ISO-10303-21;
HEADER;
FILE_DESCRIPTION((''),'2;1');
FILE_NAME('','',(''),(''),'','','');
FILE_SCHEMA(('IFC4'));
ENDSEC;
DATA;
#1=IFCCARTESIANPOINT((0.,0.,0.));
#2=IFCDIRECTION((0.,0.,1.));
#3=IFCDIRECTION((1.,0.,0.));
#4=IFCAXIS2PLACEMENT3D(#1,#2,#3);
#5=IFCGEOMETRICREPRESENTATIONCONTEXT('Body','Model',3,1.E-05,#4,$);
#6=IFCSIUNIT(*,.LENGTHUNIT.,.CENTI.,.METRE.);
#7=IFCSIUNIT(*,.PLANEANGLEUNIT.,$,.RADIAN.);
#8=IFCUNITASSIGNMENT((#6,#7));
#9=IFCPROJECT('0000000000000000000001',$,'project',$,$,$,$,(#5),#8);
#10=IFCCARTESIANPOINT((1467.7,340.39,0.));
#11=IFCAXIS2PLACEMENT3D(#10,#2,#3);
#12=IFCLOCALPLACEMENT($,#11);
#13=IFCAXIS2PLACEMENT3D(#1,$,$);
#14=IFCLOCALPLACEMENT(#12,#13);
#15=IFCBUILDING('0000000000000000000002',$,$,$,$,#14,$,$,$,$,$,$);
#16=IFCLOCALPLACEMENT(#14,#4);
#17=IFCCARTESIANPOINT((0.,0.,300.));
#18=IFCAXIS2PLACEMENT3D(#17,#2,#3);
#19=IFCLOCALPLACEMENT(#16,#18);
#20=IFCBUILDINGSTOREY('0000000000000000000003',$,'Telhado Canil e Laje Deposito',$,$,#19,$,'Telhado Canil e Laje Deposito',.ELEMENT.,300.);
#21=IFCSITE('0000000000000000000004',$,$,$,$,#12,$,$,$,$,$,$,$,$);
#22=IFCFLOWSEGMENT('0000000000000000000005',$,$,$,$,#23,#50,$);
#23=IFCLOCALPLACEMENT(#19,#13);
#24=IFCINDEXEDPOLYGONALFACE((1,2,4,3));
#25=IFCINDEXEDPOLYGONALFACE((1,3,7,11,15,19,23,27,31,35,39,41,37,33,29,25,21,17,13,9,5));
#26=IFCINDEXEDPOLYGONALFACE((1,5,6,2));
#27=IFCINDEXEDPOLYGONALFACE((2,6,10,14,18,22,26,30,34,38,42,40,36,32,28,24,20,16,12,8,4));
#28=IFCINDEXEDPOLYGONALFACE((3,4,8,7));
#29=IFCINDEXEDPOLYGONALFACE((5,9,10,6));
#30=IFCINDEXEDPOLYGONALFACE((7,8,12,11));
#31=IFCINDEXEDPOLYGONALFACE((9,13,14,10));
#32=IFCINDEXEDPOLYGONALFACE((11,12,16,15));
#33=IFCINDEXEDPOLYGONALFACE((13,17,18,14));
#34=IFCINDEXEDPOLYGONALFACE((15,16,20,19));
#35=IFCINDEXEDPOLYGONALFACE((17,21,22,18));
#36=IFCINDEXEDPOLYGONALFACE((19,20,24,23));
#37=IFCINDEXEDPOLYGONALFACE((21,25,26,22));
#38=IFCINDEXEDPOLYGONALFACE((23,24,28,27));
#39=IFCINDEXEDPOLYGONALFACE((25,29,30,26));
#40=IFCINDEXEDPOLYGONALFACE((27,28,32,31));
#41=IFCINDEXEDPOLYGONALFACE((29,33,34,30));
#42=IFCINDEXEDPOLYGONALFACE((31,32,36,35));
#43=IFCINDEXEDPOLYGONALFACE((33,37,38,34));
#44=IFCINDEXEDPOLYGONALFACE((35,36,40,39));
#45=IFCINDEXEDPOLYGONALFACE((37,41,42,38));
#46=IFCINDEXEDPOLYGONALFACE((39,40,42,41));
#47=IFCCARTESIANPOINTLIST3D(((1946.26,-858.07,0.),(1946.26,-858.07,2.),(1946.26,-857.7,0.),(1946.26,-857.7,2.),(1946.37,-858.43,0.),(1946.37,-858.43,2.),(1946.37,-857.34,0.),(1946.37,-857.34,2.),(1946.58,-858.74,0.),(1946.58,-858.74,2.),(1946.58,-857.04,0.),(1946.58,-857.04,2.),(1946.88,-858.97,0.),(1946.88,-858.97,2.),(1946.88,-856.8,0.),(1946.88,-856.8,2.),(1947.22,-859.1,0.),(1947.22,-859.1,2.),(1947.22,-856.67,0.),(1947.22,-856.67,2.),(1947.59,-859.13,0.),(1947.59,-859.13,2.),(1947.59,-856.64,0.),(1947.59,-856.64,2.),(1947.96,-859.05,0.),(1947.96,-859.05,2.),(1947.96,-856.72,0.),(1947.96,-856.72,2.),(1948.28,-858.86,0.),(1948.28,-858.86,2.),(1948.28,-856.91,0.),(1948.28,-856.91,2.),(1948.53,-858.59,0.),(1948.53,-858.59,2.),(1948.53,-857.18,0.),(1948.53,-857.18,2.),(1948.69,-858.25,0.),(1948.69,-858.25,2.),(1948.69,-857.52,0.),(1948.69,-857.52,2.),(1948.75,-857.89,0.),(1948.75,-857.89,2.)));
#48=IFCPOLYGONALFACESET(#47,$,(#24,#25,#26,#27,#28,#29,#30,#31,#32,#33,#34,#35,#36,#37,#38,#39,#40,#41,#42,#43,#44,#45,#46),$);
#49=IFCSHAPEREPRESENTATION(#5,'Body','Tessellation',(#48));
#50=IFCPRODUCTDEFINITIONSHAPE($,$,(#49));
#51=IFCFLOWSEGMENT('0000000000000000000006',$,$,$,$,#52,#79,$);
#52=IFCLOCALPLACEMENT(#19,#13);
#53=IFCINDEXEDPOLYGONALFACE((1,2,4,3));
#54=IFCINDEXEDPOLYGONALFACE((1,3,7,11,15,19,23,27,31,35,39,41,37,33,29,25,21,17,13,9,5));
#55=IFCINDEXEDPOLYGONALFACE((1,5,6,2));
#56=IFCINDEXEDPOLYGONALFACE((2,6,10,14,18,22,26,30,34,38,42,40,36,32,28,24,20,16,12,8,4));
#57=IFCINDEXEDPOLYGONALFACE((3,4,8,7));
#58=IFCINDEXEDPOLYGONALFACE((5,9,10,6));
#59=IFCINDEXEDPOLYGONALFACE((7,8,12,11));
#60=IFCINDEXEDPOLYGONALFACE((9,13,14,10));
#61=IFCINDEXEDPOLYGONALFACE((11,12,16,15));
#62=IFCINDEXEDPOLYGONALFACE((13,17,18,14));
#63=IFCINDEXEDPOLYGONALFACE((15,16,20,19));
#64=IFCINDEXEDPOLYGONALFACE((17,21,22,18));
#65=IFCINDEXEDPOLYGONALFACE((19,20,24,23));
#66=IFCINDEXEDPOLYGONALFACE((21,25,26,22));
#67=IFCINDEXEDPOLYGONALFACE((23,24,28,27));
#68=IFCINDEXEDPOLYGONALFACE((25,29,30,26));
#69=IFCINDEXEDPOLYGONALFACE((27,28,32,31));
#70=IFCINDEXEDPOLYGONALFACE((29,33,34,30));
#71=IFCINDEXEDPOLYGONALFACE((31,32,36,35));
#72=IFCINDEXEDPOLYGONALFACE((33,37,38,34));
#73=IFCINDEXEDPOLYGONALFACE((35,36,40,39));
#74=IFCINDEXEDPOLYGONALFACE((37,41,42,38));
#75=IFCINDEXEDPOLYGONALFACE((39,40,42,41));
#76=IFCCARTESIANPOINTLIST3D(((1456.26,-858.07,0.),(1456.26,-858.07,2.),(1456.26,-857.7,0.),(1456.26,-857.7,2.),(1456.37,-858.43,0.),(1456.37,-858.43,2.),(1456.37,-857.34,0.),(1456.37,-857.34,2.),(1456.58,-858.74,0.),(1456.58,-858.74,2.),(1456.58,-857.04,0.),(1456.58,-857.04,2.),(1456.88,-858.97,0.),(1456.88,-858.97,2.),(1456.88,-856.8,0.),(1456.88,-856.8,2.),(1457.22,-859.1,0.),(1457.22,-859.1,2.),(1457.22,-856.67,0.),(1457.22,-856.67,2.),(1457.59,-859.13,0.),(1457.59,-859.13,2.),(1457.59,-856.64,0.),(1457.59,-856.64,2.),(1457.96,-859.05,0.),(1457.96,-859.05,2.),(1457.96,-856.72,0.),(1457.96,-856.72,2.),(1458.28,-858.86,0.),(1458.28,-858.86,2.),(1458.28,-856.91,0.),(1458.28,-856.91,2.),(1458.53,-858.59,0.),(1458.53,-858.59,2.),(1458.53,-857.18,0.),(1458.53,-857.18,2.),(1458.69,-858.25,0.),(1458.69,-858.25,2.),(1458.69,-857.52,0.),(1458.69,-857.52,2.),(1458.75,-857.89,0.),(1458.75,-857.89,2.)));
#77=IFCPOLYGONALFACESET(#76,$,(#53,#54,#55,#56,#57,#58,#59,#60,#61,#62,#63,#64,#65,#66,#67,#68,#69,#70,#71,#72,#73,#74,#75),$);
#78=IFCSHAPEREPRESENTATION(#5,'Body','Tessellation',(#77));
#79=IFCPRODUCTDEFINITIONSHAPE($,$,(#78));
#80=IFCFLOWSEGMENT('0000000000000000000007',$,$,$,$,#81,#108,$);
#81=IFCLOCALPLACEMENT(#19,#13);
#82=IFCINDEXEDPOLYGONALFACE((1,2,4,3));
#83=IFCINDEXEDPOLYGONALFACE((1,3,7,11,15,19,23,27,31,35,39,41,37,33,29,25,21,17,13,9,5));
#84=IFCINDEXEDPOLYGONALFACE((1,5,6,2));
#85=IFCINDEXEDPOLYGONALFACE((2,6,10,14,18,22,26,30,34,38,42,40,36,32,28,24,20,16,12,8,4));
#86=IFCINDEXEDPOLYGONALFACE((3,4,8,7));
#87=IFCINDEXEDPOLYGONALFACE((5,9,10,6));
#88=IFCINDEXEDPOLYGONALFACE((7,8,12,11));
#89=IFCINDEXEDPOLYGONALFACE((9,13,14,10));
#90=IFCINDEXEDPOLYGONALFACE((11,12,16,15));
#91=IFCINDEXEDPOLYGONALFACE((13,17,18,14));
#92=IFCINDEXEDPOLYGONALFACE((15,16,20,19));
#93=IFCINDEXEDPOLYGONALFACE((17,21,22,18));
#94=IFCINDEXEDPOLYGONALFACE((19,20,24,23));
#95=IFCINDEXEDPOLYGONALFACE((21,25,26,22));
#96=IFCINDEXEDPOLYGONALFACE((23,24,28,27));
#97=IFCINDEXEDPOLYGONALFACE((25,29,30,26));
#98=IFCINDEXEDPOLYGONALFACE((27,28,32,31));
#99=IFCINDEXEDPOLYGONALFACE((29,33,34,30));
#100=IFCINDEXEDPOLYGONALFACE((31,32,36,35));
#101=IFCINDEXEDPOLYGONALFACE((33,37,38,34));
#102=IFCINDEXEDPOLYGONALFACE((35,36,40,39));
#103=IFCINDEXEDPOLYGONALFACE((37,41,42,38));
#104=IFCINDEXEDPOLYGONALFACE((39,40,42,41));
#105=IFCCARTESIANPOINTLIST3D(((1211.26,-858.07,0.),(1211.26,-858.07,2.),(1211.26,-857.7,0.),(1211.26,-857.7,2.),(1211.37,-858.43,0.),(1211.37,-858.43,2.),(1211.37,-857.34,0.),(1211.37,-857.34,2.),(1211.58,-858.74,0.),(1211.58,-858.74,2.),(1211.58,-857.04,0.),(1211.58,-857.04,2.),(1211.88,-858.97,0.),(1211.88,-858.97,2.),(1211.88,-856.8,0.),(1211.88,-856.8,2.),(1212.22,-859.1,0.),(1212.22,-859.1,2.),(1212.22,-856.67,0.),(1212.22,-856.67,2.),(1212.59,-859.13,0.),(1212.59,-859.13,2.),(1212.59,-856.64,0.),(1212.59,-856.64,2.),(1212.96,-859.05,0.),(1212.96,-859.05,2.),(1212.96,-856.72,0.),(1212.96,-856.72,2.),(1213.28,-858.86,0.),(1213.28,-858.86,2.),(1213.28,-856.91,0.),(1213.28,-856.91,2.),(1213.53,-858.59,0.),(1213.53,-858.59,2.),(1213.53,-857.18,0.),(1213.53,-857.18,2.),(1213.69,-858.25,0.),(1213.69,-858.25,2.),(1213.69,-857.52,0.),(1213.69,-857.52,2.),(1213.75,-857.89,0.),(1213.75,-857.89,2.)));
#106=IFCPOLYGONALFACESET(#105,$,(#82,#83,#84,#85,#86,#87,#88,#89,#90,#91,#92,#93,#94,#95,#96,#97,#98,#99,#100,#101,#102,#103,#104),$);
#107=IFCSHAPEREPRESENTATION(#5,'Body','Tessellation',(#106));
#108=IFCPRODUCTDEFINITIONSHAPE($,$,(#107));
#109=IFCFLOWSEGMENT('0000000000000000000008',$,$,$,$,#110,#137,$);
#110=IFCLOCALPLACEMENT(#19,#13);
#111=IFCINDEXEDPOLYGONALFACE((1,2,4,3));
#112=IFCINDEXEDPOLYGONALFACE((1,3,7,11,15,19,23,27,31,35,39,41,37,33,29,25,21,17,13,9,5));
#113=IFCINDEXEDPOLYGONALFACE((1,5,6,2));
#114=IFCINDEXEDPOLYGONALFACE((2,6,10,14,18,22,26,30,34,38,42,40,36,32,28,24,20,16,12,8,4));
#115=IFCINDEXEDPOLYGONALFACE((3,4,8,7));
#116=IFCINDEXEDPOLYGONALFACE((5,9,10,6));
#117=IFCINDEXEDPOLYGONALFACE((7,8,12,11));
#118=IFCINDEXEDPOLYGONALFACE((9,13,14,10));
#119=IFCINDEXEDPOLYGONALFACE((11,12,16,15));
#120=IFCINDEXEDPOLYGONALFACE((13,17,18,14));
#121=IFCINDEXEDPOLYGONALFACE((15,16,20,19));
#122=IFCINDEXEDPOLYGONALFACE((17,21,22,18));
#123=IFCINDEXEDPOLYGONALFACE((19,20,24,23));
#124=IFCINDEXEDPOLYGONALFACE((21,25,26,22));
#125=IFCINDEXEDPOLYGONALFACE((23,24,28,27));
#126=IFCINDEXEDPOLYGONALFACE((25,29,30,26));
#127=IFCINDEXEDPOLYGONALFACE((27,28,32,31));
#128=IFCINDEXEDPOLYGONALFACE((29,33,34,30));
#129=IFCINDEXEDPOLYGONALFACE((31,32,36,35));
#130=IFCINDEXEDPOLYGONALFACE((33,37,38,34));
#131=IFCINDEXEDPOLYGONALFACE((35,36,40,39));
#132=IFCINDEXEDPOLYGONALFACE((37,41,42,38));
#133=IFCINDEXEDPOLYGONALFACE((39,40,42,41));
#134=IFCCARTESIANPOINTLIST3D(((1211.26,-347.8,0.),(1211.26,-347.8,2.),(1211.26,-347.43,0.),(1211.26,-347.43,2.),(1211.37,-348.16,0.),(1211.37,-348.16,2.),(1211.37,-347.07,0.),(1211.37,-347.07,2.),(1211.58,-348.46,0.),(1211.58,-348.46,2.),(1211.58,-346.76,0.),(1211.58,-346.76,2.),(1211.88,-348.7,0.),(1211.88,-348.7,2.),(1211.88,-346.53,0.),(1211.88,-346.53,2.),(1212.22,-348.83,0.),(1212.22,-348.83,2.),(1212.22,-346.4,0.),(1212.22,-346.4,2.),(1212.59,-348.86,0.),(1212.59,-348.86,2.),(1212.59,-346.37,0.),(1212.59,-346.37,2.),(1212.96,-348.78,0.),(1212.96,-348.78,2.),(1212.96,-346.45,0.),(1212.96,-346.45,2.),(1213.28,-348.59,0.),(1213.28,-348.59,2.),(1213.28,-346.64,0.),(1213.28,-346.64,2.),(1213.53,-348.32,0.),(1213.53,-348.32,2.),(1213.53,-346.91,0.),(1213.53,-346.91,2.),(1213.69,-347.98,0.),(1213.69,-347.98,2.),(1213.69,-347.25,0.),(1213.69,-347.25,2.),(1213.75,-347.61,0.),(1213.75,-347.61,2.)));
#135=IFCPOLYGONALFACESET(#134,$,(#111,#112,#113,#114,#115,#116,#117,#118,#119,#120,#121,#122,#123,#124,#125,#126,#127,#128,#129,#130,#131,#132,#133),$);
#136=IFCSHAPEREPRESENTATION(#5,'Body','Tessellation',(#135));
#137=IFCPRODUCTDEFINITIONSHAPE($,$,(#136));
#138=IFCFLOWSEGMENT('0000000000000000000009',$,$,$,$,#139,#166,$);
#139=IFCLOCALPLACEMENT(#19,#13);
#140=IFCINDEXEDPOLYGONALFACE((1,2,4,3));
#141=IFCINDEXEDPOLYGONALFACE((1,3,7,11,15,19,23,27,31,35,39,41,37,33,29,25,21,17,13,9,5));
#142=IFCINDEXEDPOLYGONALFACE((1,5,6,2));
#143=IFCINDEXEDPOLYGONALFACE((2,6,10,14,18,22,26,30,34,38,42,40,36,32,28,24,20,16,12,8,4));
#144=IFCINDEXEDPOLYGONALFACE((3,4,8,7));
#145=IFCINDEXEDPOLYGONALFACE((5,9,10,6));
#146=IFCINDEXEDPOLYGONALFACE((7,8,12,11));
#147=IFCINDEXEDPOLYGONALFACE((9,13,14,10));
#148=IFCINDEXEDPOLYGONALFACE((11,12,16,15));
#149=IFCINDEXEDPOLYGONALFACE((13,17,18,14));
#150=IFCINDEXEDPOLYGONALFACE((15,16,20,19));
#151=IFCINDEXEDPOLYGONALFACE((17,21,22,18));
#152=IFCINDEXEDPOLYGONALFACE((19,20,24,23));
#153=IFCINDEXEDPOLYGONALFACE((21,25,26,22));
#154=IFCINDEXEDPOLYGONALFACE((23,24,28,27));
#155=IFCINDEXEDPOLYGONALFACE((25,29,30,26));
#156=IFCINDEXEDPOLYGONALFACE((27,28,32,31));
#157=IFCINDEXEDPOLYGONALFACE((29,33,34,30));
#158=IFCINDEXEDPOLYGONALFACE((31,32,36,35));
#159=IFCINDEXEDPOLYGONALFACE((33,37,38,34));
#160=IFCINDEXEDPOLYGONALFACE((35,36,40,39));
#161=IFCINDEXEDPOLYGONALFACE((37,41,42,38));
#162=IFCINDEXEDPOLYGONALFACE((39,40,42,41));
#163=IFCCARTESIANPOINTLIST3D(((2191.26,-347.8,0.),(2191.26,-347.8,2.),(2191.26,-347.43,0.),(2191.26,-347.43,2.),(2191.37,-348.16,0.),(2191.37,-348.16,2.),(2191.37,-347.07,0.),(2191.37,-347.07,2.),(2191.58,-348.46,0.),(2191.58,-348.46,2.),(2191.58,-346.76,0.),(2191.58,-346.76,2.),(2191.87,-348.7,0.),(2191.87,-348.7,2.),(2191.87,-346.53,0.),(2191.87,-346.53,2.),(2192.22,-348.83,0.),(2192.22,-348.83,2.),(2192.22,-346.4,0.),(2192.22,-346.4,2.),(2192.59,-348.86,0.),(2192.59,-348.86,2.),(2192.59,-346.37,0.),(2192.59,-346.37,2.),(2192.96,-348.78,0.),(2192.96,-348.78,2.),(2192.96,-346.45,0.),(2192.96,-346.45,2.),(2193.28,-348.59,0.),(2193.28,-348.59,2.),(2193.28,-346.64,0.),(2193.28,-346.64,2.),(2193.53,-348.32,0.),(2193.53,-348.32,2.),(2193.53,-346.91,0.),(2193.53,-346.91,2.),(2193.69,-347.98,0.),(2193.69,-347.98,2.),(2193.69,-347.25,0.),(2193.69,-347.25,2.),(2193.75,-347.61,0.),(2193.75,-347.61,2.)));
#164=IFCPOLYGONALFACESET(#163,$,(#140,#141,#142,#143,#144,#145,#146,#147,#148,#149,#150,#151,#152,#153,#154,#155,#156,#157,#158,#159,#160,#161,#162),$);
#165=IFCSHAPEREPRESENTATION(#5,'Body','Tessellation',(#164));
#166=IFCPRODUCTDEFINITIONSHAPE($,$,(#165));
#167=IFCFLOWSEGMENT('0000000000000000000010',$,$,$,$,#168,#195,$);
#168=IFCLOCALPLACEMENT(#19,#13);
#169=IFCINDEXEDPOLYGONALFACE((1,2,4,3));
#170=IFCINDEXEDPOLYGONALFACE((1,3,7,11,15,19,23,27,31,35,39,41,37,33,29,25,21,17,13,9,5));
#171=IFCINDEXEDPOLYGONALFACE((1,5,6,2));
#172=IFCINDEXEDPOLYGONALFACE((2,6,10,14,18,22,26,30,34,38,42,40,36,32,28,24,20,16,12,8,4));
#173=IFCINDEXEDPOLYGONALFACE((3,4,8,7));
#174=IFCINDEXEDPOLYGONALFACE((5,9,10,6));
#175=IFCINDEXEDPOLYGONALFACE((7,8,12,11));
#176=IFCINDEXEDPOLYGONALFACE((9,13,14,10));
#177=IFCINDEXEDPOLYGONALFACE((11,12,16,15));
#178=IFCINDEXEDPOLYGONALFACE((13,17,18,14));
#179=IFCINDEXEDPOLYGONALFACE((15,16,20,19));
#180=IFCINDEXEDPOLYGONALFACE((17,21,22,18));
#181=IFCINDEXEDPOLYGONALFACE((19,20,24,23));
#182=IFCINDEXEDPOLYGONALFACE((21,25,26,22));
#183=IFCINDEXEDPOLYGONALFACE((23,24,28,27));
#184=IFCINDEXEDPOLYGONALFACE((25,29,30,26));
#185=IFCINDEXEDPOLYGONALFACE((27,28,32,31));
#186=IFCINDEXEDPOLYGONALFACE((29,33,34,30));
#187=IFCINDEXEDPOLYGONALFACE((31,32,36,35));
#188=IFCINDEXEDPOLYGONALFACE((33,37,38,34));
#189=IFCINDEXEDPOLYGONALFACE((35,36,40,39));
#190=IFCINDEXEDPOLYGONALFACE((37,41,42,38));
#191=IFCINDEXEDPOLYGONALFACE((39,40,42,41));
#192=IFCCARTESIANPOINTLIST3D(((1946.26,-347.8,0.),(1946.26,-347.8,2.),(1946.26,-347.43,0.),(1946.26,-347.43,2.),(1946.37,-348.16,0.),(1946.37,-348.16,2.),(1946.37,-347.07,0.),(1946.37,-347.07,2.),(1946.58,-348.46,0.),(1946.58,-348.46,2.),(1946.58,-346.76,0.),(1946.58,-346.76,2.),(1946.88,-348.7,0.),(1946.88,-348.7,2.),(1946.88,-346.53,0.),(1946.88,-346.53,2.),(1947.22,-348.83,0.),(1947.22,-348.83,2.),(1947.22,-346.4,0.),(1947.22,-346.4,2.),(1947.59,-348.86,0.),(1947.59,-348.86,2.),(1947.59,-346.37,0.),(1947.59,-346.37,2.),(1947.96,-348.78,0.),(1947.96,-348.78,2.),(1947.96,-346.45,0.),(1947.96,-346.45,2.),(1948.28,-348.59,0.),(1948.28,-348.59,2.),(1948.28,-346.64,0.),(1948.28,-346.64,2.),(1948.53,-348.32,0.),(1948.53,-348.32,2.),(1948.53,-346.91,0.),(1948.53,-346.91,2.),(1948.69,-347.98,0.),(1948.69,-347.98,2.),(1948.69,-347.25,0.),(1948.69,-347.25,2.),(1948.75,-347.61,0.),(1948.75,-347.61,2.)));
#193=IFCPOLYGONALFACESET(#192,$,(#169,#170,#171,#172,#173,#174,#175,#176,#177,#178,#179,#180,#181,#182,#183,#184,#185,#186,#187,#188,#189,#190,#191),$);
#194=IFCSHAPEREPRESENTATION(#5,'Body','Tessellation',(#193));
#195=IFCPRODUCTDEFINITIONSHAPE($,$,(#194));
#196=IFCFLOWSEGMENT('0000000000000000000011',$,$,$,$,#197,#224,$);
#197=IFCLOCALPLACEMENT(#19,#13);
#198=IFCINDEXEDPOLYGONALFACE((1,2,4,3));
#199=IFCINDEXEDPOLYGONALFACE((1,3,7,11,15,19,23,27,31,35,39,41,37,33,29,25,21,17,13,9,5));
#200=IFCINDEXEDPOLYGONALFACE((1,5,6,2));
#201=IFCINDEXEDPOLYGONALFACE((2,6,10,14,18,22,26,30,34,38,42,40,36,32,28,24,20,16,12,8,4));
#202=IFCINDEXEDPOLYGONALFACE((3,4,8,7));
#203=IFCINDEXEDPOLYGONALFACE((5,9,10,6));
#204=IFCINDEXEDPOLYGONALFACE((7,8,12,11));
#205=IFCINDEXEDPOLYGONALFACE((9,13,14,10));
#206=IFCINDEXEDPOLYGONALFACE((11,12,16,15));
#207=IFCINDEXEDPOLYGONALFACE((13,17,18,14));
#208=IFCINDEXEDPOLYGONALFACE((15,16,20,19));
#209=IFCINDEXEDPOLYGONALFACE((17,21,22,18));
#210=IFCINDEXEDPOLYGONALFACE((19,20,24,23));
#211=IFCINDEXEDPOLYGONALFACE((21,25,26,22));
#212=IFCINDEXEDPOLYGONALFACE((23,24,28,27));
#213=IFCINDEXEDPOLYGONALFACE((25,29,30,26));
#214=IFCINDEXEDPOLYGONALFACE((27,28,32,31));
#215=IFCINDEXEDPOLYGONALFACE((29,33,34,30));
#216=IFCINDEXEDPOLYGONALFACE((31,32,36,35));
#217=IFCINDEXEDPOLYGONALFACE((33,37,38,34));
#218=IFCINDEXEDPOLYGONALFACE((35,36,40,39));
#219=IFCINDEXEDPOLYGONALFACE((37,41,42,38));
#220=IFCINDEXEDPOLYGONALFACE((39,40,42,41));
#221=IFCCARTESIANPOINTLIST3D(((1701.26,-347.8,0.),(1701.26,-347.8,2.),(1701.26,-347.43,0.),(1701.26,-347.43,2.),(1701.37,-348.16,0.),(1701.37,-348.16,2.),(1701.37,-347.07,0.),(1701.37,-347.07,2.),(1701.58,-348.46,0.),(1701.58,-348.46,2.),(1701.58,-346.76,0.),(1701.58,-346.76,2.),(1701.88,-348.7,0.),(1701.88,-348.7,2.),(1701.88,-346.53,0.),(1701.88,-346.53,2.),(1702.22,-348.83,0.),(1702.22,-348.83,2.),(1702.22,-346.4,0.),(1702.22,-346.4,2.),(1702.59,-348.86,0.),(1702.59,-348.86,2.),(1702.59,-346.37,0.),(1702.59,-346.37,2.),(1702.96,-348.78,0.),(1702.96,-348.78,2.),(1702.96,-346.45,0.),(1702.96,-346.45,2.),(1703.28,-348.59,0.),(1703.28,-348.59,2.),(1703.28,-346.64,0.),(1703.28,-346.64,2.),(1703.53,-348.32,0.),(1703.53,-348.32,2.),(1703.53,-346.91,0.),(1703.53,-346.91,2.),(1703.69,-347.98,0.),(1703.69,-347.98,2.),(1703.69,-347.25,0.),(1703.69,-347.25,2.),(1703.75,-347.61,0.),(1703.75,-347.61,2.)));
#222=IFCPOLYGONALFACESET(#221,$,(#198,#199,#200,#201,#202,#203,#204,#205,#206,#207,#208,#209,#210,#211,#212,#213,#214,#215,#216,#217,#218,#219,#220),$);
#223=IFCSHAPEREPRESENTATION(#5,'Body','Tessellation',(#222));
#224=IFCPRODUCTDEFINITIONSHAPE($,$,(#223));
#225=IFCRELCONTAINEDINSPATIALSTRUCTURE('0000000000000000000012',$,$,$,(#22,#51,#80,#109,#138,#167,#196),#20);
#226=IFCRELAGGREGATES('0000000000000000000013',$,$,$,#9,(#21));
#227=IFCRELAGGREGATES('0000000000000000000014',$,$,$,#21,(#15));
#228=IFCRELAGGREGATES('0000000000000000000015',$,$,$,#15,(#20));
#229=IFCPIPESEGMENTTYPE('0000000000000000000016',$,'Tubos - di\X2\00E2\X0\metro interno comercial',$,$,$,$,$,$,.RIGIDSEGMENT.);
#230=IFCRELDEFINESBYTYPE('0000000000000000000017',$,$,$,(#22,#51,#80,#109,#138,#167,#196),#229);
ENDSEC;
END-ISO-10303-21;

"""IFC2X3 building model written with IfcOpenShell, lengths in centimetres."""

from ifc_helpers import new_model, si_unit, frame, origin, origin_with_axes, origin_2d_with_axis, place, context, project, spatial, circle, extrude, type_object, element, save


model = new_model("IFC2X3")

# Units and contexts
model_context = context("Model", 3, precision=1e-05, world=origin_with_axes(), identifier="Body")
ifc_project = project(units=[si_unit("LENGTHUNIT", "METRE", prefix="CENTI"), si_unit("PLANEANGLEUNIT", "RADIAN")], contexts=[model_context])

# Site, building, storey
site_placement = place(None, frame((1467.7, 340.39, 0.0), z_axis=(0.0, 0.0, 1.0), x_axis=(1.0, 0.0, 0.0)))
site = spatial("IfcSite", under=ifc_project, at=site_placement)
building_placement = place(site_placement, origin())
building = spatial("IfcBuilding", under=site, at=building_placement)
placement = place(building_placement, origin_with_axes())
storey_placement = place(placement, frame((0.0, 0.0, 300.0), z_axis=(0.0, 0.0, 1.0), x_axis=(1.0, 0.0, 0.0)))
storey = spatial("IfcBuildingStorey", under=building, at=storey_placement, Name="Telhado Canil e Laje Deposito", LongName="Telhado Canil e Laje Deposito", CompositionType="ELEMENT", Elevation=300.0)

# Flow segments
pipe_segment_type_1 = type_object("IfcPipeSegmentType", Name="Tubos - diâmetro interno comercial", PredefinedType="RIGIDSEGMENT")
for number, where, z_axis, x_axis in (
    (1, (1947.5, -857.89, 2.0), (0.0, 0.0, 1.0), (1.0, 0.0, 0.0)),
    (2, (1457.5, -857.89, 2.0), (0.0, 0.0, 1.0), (1.0, 0.0, 0.0)),
    (3, (1212.5, -857.89, 2.0), (0.0, 0.0, 1.0), (1.0, 0.0, 0.0)),
    (4, (1212.5, -347.61, 2.0), (0.0, 0.0, 1.0), (1.0, 0.0, 0.0)),
    (5, (2192.5, -347.61, 2.0), (0.0, 0.0, 1.0), (1.0, 0.0, 0.0)),
    (6, (1947.5, -347.61, 2.0), (0.0, 0.0, 1.0), (1.0, 0.0, 0.0)),
    (7, (1702.5, -347.61, 2.0), (0.0, 0.0, 1.0), (1.0, 0.0, 0.0)),
):
    element("IfcFlowSegment", number, at=place(storey_placement, frame(where, z_axis=z_axis, x_axis=x_axis)), inside=storey, type_object=pipe_segment_type_1, context=model_context, shape_type="SolidModel", body=[
        extrude(circle(Radius=1.25, at=origin_2d_with_axis()), frame((0.0, 0.0, 0.0), z_axis=(0.0, 0.0, -1.0), x_axis=(1.0, 0.0, 0.0)), (0.0, 0.0, 1.0), 2.0),
    ])

save(model, "model.ifc")
